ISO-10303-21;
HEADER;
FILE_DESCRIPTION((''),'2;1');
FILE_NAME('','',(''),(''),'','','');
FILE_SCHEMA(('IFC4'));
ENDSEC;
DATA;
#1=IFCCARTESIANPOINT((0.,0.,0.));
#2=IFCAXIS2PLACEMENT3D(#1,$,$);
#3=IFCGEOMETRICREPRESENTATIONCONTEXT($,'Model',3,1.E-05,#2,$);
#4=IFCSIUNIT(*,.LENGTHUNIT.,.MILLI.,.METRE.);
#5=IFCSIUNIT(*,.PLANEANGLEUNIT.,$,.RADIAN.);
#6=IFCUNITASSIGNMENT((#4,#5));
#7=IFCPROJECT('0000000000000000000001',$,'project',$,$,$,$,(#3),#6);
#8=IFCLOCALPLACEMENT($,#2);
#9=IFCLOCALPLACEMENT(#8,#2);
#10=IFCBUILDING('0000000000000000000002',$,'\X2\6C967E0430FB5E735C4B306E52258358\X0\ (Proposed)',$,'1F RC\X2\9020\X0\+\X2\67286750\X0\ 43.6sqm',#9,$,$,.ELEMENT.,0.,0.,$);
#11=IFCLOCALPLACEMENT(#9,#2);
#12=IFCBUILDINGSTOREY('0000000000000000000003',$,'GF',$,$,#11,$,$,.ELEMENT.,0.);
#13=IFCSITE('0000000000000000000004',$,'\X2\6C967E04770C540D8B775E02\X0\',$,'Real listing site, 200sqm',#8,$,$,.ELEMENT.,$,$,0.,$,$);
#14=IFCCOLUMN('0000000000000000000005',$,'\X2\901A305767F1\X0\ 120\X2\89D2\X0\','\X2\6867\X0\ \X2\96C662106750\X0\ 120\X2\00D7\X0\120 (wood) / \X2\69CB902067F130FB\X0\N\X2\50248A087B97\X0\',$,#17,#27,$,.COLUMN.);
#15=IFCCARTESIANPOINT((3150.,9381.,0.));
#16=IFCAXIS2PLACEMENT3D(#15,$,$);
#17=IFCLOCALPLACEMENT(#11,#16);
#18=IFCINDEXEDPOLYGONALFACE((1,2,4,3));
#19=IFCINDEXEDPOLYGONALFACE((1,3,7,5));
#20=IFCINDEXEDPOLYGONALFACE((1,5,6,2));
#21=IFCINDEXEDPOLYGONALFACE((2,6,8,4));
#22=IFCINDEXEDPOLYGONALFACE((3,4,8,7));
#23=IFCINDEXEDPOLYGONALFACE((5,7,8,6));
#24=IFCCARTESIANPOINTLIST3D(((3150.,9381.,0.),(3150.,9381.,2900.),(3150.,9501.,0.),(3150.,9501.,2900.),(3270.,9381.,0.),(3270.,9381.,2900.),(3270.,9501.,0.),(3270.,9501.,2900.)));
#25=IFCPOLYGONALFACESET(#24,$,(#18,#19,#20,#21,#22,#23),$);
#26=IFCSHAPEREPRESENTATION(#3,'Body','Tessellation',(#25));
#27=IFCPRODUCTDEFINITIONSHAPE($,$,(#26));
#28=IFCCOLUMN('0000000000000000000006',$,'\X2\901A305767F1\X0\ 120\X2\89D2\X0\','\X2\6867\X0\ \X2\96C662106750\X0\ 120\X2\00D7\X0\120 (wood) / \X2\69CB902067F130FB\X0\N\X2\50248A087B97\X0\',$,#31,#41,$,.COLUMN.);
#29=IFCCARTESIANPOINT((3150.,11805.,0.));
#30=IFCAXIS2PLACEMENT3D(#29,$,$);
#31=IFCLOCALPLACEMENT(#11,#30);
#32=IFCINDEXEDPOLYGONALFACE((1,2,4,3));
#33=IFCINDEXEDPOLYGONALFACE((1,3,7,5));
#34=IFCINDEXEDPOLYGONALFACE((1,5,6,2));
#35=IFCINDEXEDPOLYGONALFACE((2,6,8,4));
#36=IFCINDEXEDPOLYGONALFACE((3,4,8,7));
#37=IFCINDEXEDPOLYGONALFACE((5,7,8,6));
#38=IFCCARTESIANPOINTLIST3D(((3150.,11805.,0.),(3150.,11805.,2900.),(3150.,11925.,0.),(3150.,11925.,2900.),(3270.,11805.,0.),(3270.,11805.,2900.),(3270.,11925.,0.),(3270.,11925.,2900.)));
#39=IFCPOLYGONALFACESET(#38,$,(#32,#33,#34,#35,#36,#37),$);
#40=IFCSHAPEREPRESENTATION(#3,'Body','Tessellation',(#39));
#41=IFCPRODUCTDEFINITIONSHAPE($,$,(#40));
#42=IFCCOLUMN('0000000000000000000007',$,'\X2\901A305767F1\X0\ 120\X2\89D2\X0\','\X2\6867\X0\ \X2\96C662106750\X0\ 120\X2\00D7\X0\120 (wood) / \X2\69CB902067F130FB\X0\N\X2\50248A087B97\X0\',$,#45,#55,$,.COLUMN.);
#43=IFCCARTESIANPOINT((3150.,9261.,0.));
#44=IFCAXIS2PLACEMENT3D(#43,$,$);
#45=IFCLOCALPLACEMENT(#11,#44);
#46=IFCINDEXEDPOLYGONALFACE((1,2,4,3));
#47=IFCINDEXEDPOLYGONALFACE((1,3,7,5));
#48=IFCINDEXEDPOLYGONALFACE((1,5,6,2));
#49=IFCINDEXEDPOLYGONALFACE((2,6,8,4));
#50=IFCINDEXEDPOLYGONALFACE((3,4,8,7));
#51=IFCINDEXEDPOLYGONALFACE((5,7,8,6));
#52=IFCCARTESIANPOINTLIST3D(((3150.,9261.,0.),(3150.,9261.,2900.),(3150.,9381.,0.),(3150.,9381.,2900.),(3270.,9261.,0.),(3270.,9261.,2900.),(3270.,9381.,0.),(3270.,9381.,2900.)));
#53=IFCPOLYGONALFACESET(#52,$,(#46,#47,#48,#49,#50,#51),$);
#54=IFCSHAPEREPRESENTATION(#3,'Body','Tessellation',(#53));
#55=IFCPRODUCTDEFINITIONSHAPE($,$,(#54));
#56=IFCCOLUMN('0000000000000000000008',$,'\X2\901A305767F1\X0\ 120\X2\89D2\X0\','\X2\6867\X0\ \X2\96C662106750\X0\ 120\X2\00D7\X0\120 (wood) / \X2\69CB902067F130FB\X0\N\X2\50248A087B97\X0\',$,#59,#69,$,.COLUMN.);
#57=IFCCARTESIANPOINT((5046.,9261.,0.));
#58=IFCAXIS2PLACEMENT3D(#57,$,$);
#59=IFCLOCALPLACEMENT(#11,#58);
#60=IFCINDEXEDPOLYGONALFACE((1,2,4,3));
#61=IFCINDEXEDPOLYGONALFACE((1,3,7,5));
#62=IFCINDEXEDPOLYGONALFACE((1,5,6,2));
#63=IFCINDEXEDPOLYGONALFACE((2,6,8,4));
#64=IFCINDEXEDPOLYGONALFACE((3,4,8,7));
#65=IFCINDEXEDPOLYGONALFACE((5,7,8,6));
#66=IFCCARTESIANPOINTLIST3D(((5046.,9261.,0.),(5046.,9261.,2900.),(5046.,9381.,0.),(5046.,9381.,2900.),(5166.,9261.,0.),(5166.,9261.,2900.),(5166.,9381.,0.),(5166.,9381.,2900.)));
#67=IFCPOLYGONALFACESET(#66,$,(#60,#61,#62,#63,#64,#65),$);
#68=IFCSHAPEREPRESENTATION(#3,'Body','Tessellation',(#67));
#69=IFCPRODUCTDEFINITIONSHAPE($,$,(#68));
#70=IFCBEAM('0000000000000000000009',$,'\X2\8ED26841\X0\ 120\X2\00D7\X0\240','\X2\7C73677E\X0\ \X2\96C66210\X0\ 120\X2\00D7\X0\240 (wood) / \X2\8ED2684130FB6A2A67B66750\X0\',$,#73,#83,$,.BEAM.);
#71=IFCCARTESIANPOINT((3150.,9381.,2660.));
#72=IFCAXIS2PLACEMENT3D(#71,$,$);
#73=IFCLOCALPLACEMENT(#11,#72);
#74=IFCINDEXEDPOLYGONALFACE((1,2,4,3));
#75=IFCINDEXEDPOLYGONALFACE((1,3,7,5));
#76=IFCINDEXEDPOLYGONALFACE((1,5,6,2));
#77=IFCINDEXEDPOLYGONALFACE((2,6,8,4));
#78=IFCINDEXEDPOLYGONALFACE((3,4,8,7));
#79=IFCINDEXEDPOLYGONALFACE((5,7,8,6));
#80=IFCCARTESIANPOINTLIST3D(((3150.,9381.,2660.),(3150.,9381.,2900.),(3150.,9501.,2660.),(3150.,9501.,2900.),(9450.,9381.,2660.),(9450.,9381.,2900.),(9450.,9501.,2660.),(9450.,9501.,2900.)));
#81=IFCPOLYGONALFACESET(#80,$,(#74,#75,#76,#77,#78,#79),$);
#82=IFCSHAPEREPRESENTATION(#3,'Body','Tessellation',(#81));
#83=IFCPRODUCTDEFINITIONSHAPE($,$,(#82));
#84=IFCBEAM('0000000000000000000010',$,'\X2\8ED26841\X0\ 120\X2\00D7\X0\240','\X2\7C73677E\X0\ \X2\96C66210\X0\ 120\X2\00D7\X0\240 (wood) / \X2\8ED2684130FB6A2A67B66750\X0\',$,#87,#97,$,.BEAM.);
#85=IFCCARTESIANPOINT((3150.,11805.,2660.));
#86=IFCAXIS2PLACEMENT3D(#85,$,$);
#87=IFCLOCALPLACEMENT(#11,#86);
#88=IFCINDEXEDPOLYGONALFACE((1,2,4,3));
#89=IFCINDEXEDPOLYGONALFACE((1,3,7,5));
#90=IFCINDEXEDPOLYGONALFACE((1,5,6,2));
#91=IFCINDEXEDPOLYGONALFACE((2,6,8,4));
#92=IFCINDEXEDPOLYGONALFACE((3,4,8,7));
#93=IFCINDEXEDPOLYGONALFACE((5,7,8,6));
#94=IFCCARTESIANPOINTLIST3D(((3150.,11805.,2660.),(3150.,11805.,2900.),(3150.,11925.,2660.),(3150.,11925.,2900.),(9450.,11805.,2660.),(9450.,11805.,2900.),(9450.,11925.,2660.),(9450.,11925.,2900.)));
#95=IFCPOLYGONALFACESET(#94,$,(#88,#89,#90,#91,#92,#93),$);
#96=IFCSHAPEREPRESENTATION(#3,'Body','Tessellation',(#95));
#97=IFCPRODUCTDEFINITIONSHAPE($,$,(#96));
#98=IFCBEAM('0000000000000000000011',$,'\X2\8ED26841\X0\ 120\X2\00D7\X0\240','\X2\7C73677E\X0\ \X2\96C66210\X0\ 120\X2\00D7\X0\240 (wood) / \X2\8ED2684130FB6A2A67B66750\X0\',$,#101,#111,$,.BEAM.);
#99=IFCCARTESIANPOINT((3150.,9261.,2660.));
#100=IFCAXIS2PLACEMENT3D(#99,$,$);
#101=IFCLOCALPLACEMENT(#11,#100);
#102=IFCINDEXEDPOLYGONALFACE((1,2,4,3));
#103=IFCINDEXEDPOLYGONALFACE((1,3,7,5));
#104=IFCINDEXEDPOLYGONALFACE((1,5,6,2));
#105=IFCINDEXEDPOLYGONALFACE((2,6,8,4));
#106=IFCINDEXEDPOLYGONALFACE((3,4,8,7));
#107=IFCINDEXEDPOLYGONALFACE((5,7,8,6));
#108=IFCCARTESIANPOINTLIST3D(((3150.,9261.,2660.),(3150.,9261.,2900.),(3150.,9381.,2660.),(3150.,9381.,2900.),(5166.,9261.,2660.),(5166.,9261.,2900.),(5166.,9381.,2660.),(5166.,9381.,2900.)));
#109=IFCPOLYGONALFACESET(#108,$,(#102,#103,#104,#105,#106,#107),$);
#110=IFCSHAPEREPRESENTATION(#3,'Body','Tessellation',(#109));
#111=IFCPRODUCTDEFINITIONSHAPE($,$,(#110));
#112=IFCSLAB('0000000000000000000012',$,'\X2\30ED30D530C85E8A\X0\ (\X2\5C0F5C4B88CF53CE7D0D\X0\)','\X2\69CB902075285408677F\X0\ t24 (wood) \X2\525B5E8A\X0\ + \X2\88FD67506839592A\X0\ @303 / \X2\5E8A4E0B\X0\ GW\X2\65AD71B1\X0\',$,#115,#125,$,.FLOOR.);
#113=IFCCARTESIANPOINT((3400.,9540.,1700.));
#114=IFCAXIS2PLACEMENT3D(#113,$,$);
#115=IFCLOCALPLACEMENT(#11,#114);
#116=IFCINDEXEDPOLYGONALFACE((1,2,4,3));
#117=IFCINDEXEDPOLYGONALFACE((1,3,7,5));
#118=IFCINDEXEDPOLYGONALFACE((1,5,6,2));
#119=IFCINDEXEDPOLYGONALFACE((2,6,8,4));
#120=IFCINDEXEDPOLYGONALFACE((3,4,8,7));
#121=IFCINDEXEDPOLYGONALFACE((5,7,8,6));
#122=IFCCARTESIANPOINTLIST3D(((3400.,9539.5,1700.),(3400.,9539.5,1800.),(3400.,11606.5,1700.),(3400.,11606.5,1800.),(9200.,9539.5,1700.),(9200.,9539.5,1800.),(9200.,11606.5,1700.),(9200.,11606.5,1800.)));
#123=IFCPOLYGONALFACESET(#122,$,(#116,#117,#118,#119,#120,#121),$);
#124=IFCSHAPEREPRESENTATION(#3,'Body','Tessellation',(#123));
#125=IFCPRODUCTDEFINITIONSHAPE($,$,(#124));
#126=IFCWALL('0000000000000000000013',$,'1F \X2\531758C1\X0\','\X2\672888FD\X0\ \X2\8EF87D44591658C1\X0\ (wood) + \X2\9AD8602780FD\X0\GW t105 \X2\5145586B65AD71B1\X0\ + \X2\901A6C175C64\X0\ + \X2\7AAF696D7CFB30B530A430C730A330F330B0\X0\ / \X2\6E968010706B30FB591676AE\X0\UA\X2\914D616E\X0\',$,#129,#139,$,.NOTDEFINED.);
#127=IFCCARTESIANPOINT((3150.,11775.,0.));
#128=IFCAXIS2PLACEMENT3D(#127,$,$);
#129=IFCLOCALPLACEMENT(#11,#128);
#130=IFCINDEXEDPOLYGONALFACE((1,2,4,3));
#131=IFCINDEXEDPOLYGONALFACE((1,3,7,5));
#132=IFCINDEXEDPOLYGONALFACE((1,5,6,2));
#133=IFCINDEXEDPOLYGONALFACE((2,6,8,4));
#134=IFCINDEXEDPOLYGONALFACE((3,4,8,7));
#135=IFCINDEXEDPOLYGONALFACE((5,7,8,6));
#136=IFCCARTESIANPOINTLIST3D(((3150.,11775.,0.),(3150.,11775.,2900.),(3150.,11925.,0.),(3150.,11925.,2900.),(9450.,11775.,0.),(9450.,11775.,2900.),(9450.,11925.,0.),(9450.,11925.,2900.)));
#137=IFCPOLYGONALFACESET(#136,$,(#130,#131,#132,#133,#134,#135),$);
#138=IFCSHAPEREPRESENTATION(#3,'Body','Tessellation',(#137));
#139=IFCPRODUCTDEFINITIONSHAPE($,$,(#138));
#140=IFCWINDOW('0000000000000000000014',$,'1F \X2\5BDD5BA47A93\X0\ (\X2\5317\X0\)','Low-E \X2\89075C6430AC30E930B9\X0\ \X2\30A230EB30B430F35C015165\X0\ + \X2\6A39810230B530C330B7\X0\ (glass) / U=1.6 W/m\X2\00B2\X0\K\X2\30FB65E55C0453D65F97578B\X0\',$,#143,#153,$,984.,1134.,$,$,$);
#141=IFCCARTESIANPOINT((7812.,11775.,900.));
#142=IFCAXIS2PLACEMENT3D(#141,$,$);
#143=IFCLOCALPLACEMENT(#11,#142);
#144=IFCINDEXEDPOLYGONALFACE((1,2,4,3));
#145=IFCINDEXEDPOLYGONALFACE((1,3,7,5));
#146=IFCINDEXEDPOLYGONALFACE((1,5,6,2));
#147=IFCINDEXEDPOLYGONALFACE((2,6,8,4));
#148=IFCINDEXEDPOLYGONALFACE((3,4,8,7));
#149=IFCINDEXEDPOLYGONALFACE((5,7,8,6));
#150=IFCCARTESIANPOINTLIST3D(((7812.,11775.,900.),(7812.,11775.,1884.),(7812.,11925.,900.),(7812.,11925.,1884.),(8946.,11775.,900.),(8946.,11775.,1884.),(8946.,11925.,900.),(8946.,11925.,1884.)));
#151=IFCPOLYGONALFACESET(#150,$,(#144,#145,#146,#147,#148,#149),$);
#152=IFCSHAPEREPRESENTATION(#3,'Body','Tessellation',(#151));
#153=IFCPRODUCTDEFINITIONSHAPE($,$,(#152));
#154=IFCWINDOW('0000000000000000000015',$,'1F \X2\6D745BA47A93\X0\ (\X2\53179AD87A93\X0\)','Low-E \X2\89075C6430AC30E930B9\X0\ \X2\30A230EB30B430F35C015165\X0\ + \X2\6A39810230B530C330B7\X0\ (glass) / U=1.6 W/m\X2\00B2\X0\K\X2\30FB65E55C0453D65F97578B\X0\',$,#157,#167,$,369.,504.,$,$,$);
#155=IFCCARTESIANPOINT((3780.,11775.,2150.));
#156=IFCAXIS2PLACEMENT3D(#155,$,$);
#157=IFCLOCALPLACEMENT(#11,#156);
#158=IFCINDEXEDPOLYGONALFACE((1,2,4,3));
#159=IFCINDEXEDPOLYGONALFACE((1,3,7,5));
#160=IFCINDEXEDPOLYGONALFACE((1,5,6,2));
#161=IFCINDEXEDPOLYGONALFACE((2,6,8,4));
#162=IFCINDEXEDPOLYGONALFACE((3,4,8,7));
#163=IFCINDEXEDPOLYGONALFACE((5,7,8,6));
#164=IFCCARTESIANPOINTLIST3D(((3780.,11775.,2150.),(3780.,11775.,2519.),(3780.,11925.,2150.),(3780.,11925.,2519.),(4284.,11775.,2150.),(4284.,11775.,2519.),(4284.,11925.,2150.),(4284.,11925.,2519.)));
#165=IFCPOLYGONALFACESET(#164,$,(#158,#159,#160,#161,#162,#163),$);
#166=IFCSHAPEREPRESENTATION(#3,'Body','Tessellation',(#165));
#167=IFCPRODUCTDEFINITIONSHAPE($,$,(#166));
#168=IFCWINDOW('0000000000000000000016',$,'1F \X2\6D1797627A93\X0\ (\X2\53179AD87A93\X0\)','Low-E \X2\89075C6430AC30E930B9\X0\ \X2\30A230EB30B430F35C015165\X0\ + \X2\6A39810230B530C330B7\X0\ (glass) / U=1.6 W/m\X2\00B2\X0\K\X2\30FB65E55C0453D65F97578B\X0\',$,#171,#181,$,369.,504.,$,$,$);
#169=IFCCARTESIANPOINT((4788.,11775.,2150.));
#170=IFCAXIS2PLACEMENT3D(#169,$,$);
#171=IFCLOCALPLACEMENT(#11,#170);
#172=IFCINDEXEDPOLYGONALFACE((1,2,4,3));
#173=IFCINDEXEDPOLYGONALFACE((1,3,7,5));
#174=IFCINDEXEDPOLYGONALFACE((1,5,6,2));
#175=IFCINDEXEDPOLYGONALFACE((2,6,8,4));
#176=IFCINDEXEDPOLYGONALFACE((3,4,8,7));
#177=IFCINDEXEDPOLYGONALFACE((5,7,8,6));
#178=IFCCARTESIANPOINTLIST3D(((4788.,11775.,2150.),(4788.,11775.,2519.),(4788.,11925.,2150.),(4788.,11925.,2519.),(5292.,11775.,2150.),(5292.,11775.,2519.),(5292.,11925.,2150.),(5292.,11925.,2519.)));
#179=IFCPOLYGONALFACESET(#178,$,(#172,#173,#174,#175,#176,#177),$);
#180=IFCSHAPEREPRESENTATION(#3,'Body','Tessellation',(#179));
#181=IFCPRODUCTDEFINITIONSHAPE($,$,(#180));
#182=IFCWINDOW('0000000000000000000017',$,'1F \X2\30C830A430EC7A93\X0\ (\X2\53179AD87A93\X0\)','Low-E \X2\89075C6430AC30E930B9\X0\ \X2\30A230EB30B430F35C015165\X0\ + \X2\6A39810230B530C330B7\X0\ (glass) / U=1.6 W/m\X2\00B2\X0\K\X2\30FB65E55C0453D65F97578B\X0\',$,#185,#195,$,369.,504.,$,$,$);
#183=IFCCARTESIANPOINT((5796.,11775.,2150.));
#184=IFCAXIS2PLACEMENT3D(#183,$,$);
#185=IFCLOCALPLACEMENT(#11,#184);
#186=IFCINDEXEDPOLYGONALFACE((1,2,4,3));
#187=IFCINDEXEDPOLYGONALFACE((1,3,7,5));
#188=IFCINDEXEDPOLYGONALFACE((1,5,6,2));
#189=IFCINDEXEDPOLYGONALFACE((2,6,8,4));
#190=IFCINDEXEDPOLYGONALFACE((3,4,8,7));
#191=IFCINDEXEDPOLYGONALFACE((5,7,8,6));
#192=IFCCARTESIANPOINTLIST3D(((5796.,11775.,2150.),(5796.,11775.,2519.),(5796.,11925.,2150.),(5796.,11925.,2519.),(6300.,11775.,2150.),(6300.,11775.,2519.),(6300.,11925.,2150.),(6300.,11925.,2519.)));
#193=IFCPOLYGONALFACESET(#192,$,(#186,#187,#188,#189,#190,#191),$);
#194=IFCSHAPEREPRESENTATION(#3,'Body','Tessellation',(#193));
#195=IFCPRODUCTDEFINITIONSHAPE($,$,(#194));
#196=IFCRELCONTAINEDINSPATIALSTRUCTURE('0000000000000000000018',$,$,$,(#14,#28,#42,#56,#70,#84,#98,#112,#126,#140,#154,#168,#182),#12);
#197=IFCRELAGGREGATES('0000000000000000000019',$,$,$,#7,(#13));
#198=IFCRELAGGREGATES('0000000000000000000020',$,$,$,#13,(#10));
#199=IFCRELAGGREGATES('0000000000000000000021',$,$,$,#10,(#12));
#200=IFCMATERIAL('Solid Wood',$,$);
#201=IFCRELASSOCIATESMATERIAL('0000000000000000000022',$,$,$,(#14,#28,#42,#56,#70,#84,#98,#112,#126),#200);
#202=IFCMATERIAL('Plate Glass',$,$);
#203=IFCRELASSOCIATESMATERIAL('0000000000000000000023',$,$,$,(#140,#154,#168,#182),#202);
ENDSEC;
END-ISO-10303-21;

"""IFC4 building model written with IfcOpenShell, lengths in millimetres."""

from ifc_helpers import new_model, si_unit, frame, frame_2d, origin, place, context, project, spatial, rectangle, extrude, material, element, fill, save


model = new_model("IFC4")

# Units and contexts
model_context = context("Model", 3, precision=1e-05, world=origin())
ifc_project = project(units=[si_unit("LENGTHUNIT", "METRE", prefix="MILLI"), si_unit("PLANEANGLEUNIT", "RADIAN")], contexts=[model_context])

# Site, building, storey
site_placement = place(None, origin())
site = spatial("IfcSite", under=ifc_project, at=site_placement, Name="沖縄県名護市", ObjectType="Real listing site, 200sqm", CompositionType="ELEMENT", RefElevation=0.0)
building_placement = place(site_placement, origin())
building = spatial("IfcBuilding", under=site, at=building_placement, Name="沖縄・平屋の別荘 (Proposed)", ObjectType="1F RC造+木材 43.6sqm", CompositionType="ELEMENT", ElevationOfRefHeight=0.0, ElevationOfTerrain=0.0)
storey_placement = place(building_placement, origin())
storey = spatial("IfcBuildingStorey", under=building, at=storey_placement, Name="GF", CompositionType="ELEMENT", Elevation=0.0)

# Columns
ifc_material_1 = material(Name="Solid Wood")
column_1_placement = place(storey_placement, frame((3150.0, 9381.0, 0.0)))
element("IfcColumn", 1, at=column_1_placement, inside=storey, material=ifc_material_1, Name="通し柱 120角", Description="桧 集成材 120×120 (wood) / 構造柱・N値計算", PredefinedType="COLUMN", context=model_context, shape_type="SweptSolid", body=[
    extrude(rectangle(XDim=120.0, YDim=120.0, at=frame_2d((60.0, 60.0))), frame((3150.0, 9381.0, 0.0)), (0.0, 0.0, 1.0), 2900.0),
])
column_2_placement = place(storey_placement, frame((3150.0, 11805.0, 0.0)))
element("IfcColumn", 2, at=column_2_placement, inside=storey, material=ifc_material_1, Name="通し柱 120角", Description="桧 集成材 120×120 (wood) / 構造柱・N値計算", PredefinedType="COLUMN", context=model_context, shape_type="SweptSolid", body=[
    extrude(rectangle(XDim=120.0, YDim=120.0, at=frame_2d((60.0, 60.0))), frame((3150.0, 11805.0, 0.0)), (0.0, 0.0, 1.0), 2900.0),
])
column_3_placement = place(storey_placement, frame((3150.0, 9261.0, 0.0)))
element("IfcColumn", 3, at=column_3_placement, inside=storey, material=ifc_material_1, Name="通し柱 120角", Description="桧 集成材 120×120 (wood) / 構造柱・N値計算", PredefinedType="COLUMN", context=model_context, shape_type="SweptSolid", body=[
    extrude(rectangle(XDim=120.0, YDim=120.0, at=frame_2d((60.0, 60.0))), frame((3150.0, 9261.0, 0.0)), (0.0, 0.0, 1.0), 2900.0),
])
column_4_placement = place(storey_placement, frame((5046.0, 9261.0, 0.0)))
element("IfcColumn", 4, at=column_4_placement, inside=storey, material=ifc_material_1, Name="通し柱 120角", Description="桧 集成材 120×120 (wood) / 構造柱・N値計算", PredefinedType="COLUMN", context=model_context, shape_type="SweptSolid", body=[
    extrude(rectangle(XDim=120.0, YDim=120.0, at=frame_2d((60.0, 60.0))), frame((5046.0, 9261.0, 0.0)), (0.0, 0.0, 1.0), 2900.0),
])

# Beams
beam_1_placement = place(storey_placement, frame((3150.0, 9381.0, 2660.0)))
element("IfcBeam", 5, at=beam_1_placement, inside=storey, material=ifc_material_1, Name="軒桁 120×240", Description="米松 集成 120×240 (wood) / 軒桁・横架材", PredefinedType="BEAM", context=model_context, shape_type="SweptSolid", body=[
    extrude(rectangle(XDim=6300.0, YDim=120.0, at=frame_2d((3150.0, 60.0))), frame((3150.0, 9381.0, 2660.0)), (0.0, 0.0, 1.0), 240.0),
])
beam_2_placement = place(storey_placement, frame((3150.0, 11805.0, 2660.0)))
element("IfcBeam", 6, at=beam_2_placement, inside=storey, material=ifc_material_1, Name="軒桁 120×240", Description="米松 集成 120×240 (wood) / 軒桁・横架材", PredefinedType="BEAM", context=model_context, shape_type="SweptSolid", body=[
    extrude(rectangle(XDim=6300.0, YDim=120.0, at=frame_2d((3150.0, 60.0))), frame((3150.0, 11805.0, 2660.0)), (0.0, 0.0, 1.0), 240.0),
])
beam_3_placement = place(storey_placement, frame((3150.0, 9261.0, 2660.0)))
element("IfcBeam", 7, at=beam_3_placement, inside=storey, material=ifc_material_1, Name="軒桁 120×240", Description="米松 集成 120×240 (wood) / 軒桁・横架材", PredefinedType="BEAM", context=model_context, shape_type="SweptSolid", body=[
    extrude(rectangle(XDim=2016.0, YDim=120.0, at=frame_2d((1008.0, 60.0))), frame((3150.0, 9261.0, 2660.0)), (0.0, 0.0, 1.0), 240.0),
])

# Slab
slab_1_placement = place(storey_placement, frame((3400.0, 9540.0, 1700.0)))
element("IfcSlab", 8, at=slab_1_placement, inside=storey, material=ifc_material_1, Name="ロフト床 (小屋裏収納)", Description="構造用合板 t24 (wood) 剛床 + 製材根太 @303 / 床下 GW断熱", PredefinedType="FLOOR", context=model_context, shape_type="SweptSolid", body=[
    extrude(rectangle(XDim=5800.0, YDim=2067.0, at=frame_2d((2900.0, 1033.0))), frame((3400.0, 9540.0, 1700.0)), (0.0, 0.0, 1.0), 100.0),
])

# Wall, openings, windows
wall_1_placement = place(storey_placement, frame((3150.0, 11775.0, 0.0)))
wall_1 = element("IfcWall", 9, at=wall_1_placement, inside=storey, material=ifc_material_1, Name="1F 北壁", Description="木製 軸組外壁 (wood) + 高性能GW t105 充填断熱 + 通気層 + 窯業系サイディング / 準耐火・外皮UA配慮", PredefinedType="NOTDEFINED", context=model_context, shape_type="SweptSolid", body=[
    extrude(rectangle(XDim=6300.0, YDim=150.0, at=frame_2d((3150.0, 75.0))), frame((3150.0, 11775.0, 0.0)), (0.0, 0.0, 1.0), 2900.0),
])
opening_1_placement = place(storey_placement, frame((7812.0, 11775.0, 900.0)))
opening_1 = element("IfcOpeningElement", 10, at=opening_1_placement, cuts=wall_1, PredefinedType="NOTDEFINED", context=model_context, shape_type="SweptSolid", body=[
    extrude(rectangle(XDim=1134.0, YDim=150.0, at=frame_2d((567.0, 75.0))), frame((7812.0, 11775.0, 900.0)), (0.0, 0.0, 1.0), 984.0),
])
opening_2_placement = place(storey_placement, frame((3780.0, 11775.0, 2150.0)))
opening_2 = element("IfcOpeningElement", 11, at=opening_2_placement, cuts=wall_1, PredefinedType="NOTDEFINED", context=model_context, shape_type="SweptSolid", body=[
    extrude(rectangle(XDim=504.0, YDim=150.0, at=frame_2d((252.0, 75.0))), frame((3780.0, 11775.0, 2150.0)), (0.0, 0.0, 1.0), 369.0),
])
opening_3_placement = place(storey_placement, frame((4788.0, 11775.0, 2150.0)))
opening_3 = element("IfcOpeningElement", 12, at=opening_3_placement, cuts=wall_1, PredefinedType="NOTDEFINED", context=model_context, shape_type="SweptSolid", body=[
    extrude(rectangle(XDim=504.0, YDim=150.0, at=frame_2d((252.0, 75.0))), frame((4788.0, 11775.0, 2150.0)), (0.0, 0.0, 1.0), 369.0),
])
opening_4_placement = place(storey_placement, frame((5796.0, 11775.0, 2150.0)))
opening_4 = element("IfcOpeningElement", 13, at=opening_4_placement, cuts=wall_1, PredefinedType="NOTDEFINED", context=model_context, shape_type="SweptSolid", body=[
    extrude(rectangle(XDim=504.0, YDim=150.0, at=frame_2d((252.0, 75.0))), frame((5796.0, 11775.0, 2150.0)), (0.0, 0.0, 1.0), 369.0),
])
ifc_material_2 = material(Name="Plate Glass")
window_1_placement = place(storey_placement, frame((7812.0, 11775.0, 900.0)))
window_1 = element("IfcWindow", 14, at=window_1_placement, inside=storey, material=ifc_material_2, Name="1F 寝室窓 (北)", Description="Low-E 複層ガラス アルゴン封入 + 樹脂サッシ (glass) / U=1.6 W/m²K・日射取得型", OverallHeight=984.0, OverallWidth=1134.0, context=model_context, shape_type="SweptSolid", body=[
    extrude(rectangle(XDim=1134.0, YDim=150.0, at=frame_2d((567.0, 75.0))), frame((7812.0, 11775.0, 900.0)), (0.0, 0.0, 1.0), 984.0),
])
fill(opening_1, window_1)
window_2_placement = place(storey_placement, frame((3780.0, 11775.0, 2150.0)))
window_2 = element("IfcWindow", 15, at=window_2_placement, inside=storey, material=ifc_material_2, Name="1F 浴室窓 (北高窓)", Description="Low-E 複層ガラス アルゴン封入 + 樹脂サッシ (glass) / U=1.6 W/m²K・日射取得型", OverallHeight=369.0, OverallWidth=504.0, context=model_context, shape_type="SweptSolid", body=[
    extrude(rectangle(XDim=504.0, YDim=150.0, at=frame_2d((252.0, 75.0))), frame((3780.0, 11775.0, 2150.0)), (0.0, 0.0, 1.0), 369.0),
])
fill(opening_2, window_2)
window_3_placement = place(storey_placement, frame((4788.0, 11775.0, 2150.0)))
window_3 = element("IfcWindow", 16, at=window_3_placement, inside=storey, material=ifc_material_2, Name="1F 洗面窓 (北高窓)", Description="Low-E 複層ガラス アルゴン封入 + 樹脂サッシ (glass) / U=1.6 W/m²K・日射取得型", OverallHeight=369.0, OverallWidth=504.0, context=model_context, shape_type="SweptSolid", body=[
    extrude(rectangle(XDim=504.0, YDim=150.0, at=frame_2d((252.0, 75.0))), frame((4788.0, 11775.0, 2150.0)), (0.0, 0.0, 1.0), 369.0),
])
fill(opening_3, window_3)
window_4_placement = place(storey_placement, frame((5796.0, 11775.0, 2150.0)))
window_4 = element("IfcWindow", 17, at=window_4_placement, inside=storey, material=ifc_material_2, Name="1F トイレ窓 (北高窓)", Description="Low-E 複層ガラス アルゴン封入 + 樹脂サッシ (glass) / U=1.6 W/m²K・日射取得型", OverallHeight=369.0, OverallWidth=504.0, context=model_context, shape_type="SweptSolid", body=[
    extrude(rectangle(XDim=504.0, YDim=150.0, at=frame_2d((252.0, 75.0))), frame((5796.0, 11775.0, 2150.0)), (0.0, 0.0, 1.0), 369.0),
])
fill(opening_4, window_4)

save(model, "model.ifc")
